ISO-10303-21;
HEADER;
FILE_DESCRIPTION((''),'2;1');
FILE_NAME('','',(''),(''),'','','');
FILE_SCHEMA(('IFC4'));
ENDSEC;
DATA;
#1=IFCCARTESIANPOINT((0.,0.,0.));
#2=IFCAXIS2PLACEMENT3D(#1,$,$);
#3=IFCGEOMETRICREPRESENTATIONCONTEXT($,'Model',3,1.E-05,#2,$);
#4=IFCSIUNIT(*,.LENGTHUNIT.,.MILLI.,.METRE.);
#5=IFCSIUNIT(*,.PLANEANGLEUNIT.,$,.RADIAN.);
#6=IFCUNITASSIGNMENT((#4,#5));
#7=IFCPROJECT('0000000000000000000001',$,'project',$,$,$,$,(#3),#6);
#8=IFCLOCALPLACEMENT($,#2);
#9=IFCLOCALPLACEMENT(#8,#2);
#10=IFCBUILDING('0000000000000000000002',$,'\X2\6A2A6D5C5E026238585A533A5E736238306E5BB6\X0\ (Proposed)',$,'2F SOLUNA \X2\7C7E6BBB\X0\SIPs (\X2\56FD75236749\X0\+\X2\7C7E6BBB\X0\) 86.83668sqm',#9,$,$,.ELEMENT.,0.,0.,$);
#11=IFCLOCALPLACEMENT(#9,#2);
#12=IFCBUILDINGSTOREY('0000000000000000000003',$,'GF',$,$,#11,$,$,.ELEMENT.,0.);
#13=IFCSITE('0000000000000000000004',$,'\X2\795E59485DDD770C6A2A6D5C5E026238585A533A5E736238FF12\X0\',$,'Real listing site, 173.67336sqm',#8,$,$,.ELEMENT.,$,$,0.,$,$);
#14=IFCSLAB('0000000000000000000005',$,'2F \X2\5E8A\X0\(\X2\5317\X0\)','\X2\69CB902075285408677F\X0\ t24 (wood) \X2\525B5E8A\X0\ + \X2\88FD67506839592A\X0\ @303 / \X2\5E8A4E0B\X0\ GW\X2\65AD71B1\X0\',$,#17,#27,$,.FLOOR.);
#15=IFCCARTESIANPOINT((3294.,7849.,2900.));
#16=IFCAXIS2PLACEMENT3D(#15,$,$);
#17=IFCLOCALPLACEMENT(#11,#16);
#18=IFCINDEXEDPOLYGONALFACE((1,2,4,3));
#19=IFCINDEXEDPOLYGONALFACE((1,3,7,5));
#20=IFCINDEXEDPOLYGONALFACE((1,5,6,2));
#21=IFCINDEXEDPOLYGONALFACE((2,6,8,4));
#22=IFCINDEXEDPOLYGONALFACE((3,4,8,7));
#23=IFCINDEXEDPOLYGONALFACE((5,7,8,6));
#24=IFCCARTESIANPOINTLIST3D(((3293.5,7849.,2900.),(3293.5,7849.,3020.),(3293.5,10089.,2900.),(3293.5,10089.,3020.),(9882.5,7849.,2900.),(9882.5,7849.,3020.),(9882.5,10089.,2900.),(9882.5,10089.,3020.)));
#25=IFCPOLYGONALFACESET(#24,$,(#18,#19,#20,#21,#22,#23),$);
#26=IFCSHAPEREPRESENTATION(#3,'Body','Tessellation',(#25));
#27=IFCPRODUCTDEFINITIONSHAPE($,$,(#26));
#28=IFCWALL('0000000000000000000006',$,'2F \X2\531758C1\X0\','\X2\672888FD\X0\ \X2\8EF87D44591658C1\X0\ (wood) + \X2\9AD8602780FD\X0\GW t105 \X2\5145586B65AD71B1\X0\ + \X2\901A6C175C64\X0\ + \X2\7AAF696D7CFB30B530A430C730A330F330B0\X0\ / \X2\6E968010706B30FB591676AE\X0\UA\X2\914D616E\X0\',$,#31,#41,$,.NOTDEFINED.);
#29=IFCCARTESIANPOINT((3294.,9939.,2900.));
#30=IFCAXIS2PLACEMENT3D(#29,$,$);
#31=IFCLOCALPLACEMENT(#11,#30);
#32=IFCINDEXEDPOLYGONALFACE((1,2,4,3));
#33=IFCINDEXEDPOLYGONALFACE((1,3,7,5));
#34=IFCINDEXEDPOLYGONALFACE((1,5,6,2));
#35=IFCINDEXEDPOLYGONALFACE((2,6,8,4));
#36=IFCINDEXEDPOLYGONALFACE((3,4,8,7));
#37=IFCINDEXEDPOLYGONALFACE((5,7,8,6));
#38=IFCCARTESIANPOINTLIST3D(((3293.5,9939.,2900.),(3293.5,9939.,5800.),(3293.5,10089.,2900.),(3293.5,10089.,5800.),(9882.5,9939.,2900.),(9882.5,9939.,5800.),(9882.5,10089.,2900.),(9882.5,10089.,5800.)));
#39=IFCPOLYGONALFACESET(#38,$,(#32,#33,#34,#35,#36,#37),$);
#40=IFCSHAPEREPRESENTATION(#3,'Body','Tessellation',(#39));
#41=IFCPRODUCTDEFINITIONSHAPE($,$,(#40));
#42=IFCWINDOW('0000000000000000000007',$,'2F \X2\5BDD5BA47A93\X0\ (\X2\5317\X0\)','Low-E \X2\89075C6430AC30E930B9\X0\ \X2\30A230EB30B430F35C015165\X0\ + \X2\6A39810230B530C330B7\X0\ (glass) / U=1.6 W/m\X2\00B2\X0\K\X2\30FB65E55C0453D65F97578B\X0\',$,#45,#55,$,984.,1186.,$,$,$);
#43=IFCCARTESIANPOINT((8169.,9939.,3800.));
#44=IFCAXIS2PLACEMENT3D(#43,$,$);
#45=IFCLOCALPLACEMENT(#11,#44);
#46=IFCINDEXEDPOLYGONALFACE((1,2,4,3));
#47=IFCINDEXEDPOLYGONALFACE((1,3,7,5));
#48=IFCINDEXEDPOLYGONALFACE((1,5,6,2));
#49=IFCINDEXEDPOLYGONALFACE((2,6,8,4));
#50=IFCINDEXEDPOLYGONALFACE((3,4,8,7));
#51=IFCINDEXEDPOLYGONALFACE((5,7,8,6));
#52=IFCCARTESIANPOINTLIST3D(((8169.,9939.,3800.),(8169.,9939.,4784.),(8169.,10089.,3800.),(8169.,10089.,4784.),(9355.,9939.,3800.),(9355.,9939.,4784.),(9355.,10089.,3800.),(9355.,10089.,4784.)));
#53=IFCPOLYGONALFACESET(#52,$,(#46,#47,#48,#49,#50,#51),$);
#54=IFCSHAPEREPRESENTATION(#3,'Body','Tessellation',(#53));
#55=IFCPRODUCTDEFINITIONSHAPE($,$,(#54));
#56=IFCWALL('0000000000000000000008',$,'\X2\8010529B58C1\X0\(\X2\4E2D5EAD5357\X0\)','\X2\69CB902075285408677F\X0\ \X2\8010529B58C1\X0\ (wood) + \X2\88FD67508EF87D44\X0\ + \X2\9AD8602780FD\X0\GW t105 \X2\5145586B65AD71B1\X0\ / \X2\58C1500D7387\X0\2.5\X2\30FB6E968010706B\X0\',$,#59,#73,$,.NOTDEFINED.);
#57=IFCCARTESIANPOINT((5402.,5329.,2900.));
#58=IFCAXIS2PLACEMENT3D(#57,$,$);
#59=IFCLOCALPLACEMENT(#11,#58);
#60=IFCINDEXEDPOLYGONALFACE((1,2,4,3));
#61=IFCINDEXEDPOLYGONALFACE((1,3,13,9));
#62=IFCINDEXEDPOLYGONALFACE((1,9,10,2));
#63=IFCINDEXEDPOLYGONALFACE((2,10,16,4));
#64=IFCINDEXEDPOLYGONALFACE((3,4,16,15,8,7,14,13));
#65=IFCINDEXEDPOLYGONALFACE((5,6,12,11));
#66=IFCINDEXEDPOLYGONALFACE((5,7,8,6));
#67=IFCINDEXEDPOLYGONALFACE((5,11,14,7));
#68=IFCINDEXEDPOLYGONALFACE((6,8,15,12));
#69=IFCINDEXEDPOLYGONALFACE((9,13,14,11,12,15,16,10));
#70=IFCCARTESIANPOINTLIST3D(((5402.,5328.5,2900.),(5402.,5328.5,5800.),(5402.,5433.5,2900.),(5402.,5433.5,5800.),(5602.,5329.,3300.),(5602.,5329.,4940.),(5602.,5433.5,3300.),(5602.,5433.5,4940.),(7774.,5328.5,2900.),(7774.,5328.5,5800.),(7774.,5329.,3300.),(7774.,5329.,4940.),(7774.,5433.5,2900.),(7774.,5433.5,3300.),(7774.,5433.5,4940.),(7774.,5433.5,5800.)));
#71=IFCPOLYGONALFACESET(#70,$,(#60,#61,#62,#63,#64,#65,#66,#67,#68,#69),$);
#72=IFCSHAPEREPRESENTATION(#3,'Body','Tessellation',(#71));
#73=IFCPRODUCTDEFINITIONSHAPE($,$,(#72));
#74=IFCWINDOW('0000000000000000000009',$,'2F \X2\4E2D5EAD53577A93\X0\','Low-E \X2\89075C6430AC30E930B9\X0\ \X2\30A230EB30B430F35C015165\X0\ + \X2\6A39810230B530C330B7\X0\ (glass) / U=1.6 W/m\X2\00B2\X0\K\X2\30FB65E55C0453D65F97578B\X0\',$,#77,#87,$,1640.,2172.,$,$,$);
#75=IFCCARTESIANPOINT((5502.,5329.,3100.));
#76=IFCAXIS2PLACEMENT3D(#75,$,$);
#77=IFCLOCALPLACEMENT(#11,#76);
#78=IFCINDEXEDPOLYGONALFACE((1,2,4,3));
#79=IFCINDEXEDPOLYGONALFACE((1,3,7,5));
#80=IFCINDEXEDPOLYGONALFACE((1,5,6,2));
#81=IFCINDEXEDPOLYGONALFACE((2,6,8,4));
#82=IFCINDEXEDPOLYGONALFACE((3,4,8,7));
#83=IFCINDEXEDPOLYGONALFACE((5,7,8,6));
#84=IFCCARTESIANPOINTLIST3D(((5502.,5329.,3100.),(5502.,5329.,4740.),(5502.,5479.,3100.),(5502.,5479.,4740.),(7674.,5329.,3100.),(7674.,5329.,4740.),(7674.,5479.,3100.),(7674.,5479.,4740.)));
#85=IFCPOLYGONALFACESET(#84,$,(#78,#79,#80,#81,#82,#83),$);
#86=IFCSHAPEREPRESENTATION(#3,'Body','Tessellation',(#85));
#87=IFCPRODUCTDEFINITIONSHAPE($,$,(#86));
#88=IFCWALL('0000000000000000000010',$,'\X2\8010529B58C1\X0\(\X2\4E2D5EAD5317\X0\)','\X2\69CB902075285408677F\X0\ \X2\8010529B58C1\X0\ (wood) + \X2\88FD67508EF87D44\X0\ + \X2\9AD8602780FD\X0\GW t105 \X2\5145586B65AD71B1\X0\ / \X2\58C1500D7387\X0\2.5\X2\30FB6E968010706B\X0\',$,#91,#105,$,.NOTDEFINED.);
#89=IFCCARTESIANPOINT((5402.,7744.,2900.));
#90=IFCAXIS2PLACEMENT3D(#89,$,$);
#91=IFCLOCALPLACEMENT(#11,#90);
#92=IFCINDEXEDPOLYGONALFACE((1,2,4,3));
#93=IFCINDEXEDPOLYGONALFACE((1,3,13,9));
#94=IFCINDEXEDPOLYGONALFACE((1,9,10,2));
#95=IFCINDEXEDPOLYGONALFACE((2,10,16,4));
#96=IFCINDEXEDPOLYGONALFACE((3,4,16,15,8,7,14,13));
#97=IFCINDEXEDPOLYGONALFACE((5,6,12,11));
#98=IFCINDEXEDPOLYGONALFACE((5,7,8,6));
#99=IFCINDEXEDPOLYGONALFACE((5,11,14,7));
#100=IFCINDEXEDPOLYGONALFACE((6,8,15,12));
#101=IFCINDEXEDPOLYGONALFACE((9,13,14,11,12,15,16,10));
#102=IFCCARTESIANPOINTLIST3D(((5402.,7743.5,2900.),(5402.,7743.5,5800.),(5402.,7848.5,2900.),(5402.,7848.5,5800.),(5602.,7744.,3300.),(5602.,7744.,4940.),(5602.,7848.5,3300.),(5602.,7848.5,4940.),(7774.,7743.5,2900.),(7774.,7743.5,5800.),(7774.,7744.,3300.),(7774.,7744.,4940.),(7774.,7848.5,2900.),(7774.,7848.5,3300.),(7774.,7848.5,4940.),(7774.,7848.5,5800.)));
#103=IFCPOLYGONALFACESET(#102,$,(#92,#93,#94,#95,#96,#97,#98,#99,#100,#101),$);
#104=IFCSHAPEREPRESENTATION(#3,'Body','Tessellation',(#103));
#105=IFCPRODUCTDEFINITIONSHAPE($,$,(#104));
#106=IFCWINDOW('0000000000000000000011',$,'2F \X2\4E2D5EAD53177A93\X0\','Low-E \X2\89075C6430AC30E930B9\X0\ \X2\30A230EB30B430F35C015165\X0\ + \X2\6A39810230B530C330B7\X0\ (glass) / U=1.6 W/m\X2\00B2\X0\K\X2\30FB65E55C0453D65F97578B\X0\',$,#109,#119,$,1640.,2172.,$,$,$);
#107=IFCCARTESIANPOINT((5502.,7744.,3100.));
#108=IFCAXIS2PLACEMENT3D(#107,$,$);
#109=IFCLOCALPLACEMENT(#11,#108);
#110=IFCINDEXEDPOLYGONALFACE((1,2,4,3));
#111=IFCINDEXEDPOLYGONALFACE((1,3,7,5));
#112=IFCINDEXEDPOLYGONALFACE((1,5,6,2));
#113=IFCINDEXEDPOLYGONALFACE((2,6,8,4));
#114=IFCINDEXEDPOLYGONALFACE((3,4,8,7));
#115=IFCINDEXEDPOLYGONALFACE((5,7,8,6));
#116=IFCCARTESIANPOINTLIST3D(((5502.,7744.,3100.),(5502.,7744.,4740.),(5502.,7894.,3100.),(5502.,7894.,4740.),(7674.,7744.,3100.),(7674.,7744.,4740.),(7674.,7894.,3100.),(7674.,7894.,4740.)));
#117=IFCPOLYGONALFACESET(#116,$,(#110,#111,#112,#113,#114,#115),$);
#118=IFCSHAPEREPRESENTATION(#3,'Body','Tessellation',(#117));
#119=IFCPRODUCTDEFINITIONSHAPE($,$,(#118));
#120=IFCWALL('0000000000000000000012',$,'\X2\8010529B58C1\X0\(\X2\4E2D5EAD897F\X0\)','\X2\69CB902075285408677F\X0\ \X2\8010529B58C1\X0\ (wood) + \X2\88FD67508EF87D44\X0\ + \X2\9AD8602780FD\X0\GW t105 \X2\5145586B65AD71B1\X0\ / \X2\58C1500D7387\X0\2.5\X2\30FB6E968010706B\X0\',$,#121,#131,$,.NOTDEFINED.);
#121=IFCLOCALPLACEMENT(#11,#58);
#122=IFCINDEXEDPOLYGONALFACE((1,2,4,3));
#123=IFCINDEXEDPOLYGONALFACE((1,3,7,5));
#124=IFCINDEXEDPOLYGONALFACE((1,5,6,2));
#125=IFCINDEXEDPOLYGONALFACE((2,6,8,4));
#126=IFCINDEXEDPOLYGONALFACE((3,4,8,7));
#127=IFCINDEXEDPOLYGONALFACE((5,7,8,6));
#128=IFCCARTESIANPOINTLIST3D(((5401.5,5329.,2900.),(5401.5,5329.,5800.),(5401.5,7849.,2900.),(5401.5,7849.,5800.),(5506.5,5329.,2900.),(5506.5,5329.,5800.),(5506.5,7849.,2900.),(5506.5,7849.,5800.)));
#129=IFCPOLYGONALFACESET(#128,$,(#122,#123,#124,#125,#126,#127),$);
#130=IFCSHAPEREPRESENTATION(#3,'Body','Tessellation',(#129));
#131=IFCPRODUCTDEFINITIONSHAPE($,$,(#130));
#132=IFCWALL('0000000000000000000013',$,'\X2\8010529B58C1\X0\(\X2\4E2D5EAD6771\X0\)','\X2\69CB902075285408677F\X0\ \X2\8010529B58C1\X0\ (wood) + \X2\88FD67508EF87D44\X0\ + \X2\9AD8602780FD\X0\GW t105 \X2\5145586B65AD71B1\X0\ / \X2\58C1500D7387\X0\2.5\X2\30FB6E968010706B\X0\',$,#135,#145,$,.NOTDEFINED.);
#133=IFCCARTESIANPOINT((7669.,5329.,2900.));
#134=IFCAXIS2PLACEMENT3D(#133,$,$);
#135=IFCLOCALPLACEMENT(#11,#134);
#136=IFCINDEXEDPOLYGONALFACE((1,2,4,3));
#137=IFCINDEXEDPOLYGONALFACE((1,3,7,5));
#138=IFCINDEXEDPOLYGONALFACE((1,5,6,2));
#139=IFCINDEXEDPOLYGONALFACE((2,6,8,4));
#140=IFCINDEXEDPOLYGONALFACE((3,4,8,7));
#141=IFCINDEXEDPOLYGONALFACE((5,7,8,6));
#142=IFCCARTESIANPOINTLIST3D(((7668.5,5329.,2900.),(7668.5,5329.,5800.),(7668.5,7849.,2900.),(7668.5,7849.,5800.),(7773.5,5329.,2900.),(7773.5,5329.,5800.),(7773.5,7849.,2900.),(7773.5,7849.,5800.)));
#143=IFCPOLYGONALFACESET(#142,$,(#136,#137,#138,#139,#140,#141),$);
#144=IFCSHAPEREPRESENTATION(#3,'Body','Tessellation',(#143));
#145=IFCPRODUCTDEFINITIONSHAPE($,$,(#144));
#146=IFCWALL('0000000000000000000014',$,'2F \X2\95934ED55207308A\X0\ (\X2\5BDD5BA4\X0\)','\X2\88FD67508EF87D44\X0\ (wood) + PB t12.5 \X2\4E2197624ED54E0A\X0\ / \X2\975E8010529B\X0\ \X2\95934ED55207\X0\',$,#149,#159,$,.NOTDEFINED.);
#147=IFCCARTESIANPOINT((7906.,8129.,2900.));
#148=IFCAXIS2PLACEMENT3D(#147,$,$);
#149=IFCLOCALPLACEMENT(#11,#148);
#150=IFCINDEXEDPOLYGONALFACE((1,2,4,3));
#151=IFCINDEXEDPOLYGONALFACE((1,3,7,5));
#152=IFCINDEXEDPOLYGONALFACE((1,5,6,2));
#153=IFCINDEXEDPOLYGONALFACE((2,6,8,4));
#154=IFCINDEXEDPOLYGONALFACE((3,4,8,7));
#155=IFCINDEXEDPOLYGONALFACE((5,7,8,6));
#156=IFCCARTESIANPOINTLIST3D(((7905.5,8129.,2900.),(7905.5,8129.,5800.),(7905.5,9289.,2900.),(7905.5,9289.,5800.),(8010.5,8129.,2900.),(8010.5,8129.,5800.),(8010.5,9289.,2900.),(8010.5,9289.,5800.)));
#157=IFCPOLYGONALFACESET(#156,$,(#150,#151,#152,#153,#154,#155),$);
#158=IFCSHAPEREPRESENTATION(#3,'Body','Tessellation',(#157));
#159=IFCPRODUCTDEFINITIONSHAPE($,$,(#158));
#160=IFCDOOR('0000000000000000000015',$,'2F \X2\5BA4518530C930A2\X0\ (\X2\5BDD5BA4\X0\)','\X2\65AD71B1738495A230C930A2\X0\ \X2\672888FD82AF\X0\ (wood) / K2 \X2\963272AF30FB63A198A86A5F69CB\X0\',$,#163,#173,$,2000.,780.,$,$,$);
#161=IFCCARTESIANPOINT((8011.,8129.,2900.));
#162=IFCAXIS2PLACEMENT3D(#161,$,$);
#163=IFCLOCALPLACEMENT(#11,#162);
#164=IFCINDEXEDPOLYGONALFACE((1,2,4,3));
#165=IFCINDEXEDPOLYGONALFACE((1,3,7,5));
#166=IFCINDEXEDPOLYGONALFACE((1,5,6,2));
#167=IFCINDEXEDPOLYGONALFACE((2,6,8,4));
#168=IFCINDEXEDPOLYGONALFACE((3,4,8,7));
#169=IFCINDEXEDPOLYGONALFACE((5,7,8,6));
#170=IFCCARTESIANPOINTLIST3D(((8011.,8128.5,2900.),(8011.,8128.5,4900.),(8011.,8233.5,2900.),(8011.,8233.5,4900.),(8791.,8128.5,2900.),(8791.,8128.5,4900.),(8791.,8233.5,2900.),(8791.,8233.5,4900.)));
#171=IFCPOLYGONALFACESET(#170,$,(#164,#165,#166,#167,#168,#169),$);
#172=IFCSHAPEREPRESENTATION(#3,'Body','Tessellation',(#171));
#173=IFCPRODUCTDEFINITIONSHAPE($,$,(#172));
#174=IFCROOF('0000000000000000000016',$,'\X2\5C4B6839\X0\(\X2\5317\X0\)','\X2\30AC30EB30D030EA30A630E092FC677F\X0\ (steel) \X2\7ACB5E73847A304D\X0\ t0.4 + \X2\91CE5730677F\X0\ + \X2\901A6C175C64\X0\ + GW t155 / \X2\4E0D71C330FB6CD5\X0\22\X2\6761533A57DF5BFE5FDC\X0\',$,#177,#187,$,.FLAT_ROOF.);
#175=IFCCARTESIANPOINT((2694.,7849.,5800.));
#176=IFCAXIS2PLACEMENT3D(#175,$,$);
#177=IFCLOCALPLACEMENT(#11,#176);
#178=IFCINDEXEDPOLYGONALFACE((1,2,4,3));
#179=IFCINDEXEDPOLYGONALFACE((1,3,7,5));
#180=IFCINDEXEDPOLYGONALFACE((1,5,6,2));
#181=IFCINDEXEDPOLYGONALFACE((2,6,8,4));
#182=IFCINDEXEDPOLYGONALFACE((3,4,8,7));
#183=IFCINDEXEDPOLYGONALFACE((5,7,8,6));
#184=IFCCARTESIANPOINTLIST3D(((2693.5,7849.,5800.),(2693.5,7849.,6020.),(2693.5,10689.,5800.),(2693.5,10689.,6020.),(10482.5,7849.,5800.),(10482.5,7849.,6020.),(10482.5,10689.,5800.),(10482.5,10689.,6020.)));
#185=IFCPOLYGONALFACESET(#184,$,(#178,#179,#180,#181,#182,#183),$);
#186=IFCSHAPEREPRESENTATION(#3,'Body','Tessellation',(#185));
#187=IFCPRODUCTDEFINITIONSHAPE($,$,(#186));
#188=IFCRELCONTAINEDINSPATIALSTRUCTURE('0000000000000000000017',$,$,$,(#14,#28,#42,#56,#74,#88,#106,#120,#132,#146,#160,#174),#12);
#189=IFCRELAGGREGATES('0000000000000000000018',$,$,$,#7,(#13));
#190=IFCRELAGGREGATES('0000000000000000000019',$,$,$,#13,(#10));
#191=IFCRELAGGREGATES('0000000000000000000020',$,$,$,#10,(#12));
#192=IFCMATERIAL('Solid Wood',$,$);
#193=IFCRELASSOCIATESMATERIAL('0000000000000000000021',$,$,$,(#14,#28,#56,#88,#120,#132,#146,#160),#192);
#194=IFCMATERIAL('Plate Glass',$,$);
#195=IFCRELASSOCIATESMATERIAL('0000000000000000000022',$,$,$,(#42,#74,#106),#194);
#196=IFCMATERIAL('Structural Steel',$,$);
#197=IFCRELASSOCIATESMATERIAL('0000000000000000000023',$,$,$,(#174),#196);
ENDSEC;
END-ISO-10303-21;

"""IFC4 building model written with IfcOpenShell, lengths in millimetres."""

from ifc_helpers import new_model, si_unit, frame, frame_2d, origin, place, context, project, spatial, rectangle, extrude, material, element, fill, save


model = new_model("IFC4")

# Units and contexts
model_context = context("Model", 3, precision=1e-05, world=origin())
ifc_project = project(units=[si_unit("LENGTHUNIT", "METRE", prefix="MILLI"), si_unit("PLANEANGLEUNIT", "RADIAN")], contexts=[model_context])

# Site, building, storey
site_placement = place(None, origin())
site = spatial("IfcSite", under=ifc_project, at=site_placement, Name="神奈川県横浜市戸塚区平戸２", ObjectType="Real listing site, 173.67336sqm", CompositionType="ELEMENT", RefElevation=0.0)
building_placement = place(site_placement, origin())
building = spatial("IfcBuilding", under=site, at=building_placement, Name="横浜市戸塚区平戸の家 (Proposed)", ObjectType="2F SOLUNA 籾殻SIPs (国産杉+籾殻) 86.83668sqm", CompositionType="ELEMENT", ElevationOfRefHeight=0.0, ElevationOfTerrain=0.0)
storey_placement = place(building_placement, origin())
storey = spatial("IfcBuildingStorey", under=building, at=storey_placement, Name="GF", CompositionType="ELEMENT", Elevation=0.0)

# Slab
ifc_material_1 = material(Name="Solid Wood")
slab_placement = place(storey_placement, frame((3294.0, 7849.0, 2900.0)))
element("IfcSlab", 1, at=slab_placement, inside=storey, material=ifc_material_1, Name="2F 床(北)", Description="構造用合板 t24 (wood) 剛床 + 製材根太 @303 / 床下 GW断熱", PredefinedType="FLOOR", context=model_context, shape_type="SweptSolid", body=[
    extrude(rectangle(XDim=6589.0, YDim=2240.0, at=frame_2d((3294.0, 1120.0))), frame((3294.0, 7849.0, 2900.0)), (0.0, 0.0, 1.0), 120.0),
])

# Walls, openings, windows
wall_1_placement = place(storey_placement, frame((3294.0, 9939.0, 2900.0)))
wall_1 = element("IfcWall", 2, at=wall_1_placement, inside=storey, material=ifc_material_1, Name="2F 北壁", Description="木製 軸組外壁 (wood) + 高性能GW t105 充填断熱 + 通気層 + 窯業系サイディング / 準耐火・外皮UA配慮", PredefinedType="NOTDEFINED", context=model_context, shape_type="SweptSolid", body=[
    extrude(rectangle(XDim=6589.0, YDim=150.0, at=frame_2d((3294.0, 75.0))), frame((3294.0, 9939.0, 2900.0)), (0.0, 0.0, 1.0), 2900.0),
])
opening_1_placement = place(storey_placement, frame((8169.0, 9939.0, 3800.0)))
opening_1 = element("IfcOpeningElement", 3, at=opening_1_placement, cuts=wall_1, PredefinedType="NOTDEFINED", context=model_context, shape_type="SweptSolid", body=[
    extrude(rectangle(XDim=1186.0, YDim=150.0, at=frame_2d((593.0, 75.0))), frame((8169.0, 9939.0, 3800.0)), (0.0, 0.0, 1.0), 984.0),
])
ifc_material_2 = material(Name="Plate Glass")
window_1_placement = place(storey_placement, frame((8169.0, 9939.0, 3800.0)))
window_1 = element("IfcWindow", 4, at=window_1_placement, inside=storey, material=ifc_material_2, Name="2F 寝室窓 (北)", Description="Low-E 複層ガラス アルゴン封入 + 樹脂サッシ (glass) / U=1.6 W/m²K・日射取得型", OverallHeight=984.0, OverallWidth=1186.0, context=model_context, shape_type="SweptSolid", body=[
    extrude(rectangle(XDim=1186.0, YDim=150.0, at=frame_2d((593.0, 75.0))), frame((8169.0, 9939.0, 3800.0)), (0.0, 0.0, 1.0), 984.0),
])
fill(opening_1, window_1)
wall_2_placement = place(storey_placement, frame((5402.0, 5329.0, 2900.0)))
wall_2 = element("IfcWall", 5, at=wall_2_placement, inside=storey, material=ifc_material_1, Name="耐力壁(中庭南)", Description="構造用合板 耐力壁 (wood) + 製材軸組 + 高性能GW t105 充填断熱 / 壁倍率2.5・準耐火", PredefinedType="NOTDEFINED", context=model_context, shape_type="SweptSolid", body=[
    extrude(rectangle(XDim=2372.0, YDim=105.0, at=frame_2d((1186.0, 52.0))), frame((5402.0, 5329.0, 2900.0)), (0.0, 0.0, 1.0), 2900.0),
])
opening_2_placement = place(storey_placement, frame((5502.0, 5329.0, 3100.0)))
opening_2 = element("IfcOpeningElement", 6, at=opening_2_placement, cuts=wall_2, PredefinedType="NOTDEFINED", context=model_context, shape_type="SweptSolid", body=[
    extrude(rectangle(XDim=2172.0, YDim=150.0, at=frame_2d((1086.0, 75.0))), frame((5502.0, 5329.0, 3100.0)), (0.0, 0.0, 1.0), 1640.0),
])
window_2_placement = place(storey_placement, frame((5502.0, 5329.0, 3100.0)))
window_2 = element("IfcWindow", 7, at=window_2_placement, inside=storey, material=ifc_material_2, Name="2F 中庭南窓", Description="Low-E 複層ガラス アルゴン封入 + 樹脂サッシ (glass) / U=1.6 W/m²K・日射取得型", OverallHeight=1640.0, OverallWidth=2172.0, context=model_context, shape_type="SweptSolid", body=[
    extrude(rectangle(XDim=2172.0, YDim=150.0, at=frame_2d((1086.0, 75.0))), frame((5502.0, 5329.0, 3100.0)), (0.0, 0.0, 1.0), 1640.0),
])
fill(opening_2, window_2)
wall_3_placement = place(storey_placement, frame((5402.0, 7744.0, 2900.0)))
wall_3 = element("IfcWall", 8, at=wall_3_placement, inside=storey, material=ifc_material_1, Name="耐力壁(中庭北)", Description="構造用合板 耐力壁 (wood) + 製材軸組 + 高性能GW t105 充填断熱 / 壁倍率2.5・準耐火", PredefinedType="NOTDEFINED", context=model_context, shape_type="SweptSolid", body=[
    extrude(rectangle(XDim=2372.0, YDim=105.0, at=frame_2d((1186.0, 52.0))), frame((5402.0, 7744.0, 2900.0)), (0.0, 0.0, 1.0), 2900.0),
])
opening_3_placement = place(storey_placement, frame((5502.0, 7744.0, 3100.0)))
opening_3 = element("IfcOpeningElement", 9, at=opening_3_placement, cuts=wall_3, PredefinedType="NOTDEFINED", context=model_context, shape_type="SweptSolid", body=[
    extrude(rectangle(XDim=2172.0, YDim=150.0, at=frame_2d((1086.0, 75.0))), frame((5502.0, 7744.0, 3100.0)), (0.0, 0.0, 1.0), 1640.0),
])
window_3_placement = place(storey_placement, frame((5502.0, 7744.0, 3100.0)))
window_3 = element("IfcWindow", 10, at=window_3_placement, inside=storey, material=ifc_material_2, Name="2F 中庭北窓", Description="Low-E 複層ガラス アルゴン封入 + 樹脂サッシ (glass) / U=1.6 W/m²K・日射取得型", OverallHeight=1640.0, OverallWidth=2172.0, context=model_context, shape_type="SweptSolid", body=[
    extrude(rectangle(XDim=2172.0, YDim=150.0, at=frame_2d((1086.0, 75.0))), frame((5502.0, 7744.0, 3100.0)), (0.0, 0.0, 1.0), 1640.0),
])
fill(opening_3, window_3)

# Walls
wall_4_placement = place(storey_placement, frame((5402.0, 5329.0, 2900.0)))
element("IfcWall", 11, at=wall_4_placement, inside=storey, material=ifc_material_1, Name="耐力壁(中庭西)", Description="構造用合板 耐力壁 (wood) + 製材軸組 + 高性能GW t105 充填断熱 / 壁倍率2.5・準耐火", PredefinedType="NOTDEFINED", context=model_context, shape_type="SweptSolid", body=[
    extrude(rectangle(XDim=105.0, YDim=2520.0, at=frame_2d((52.0, 1260.0))), frame((5402.0, 5329.0, 2900.0)), (0.0, 0.0, 1.0), 2900.0),
])
wall_5_placement = place(storey_placement, frame((7669.0, 5329.0, 2900.0)))
element("IfcWall", 12, at=wall_5_placement, inside=storey, material=ifc_material_1, Name="耐力壁(中庭東)", Description="構造用合板 耐力壁 (wood) + 製材軸組 + 高性能GW t105 充填断熱 / 壁倍率2.5・準耐火", PredefinedType="NOTDEFINED", context=model_context, shape_type="SweptSolid", body=[
    extrude(rectangle(XDim=105.0, YDim=2520.0, at=frame_2d((52.0, 1260.0))), frame((7669.0, 5329.0, 2900.0)), (0.0, 0.0, 1.0), 2900.0),
])
wall_6_placement = place(storey_placement, frame((7906.0, 8129.0, 2900.0)))
element("IfcWall", 13, at=wall_6_placement, inside=storey, material=ifc_material_1, Name="2F 間仕切り (寝室)", Description="製材軸組 (wood) + PB t12.5 両面仕上 / 非耐力 間仕切", PredefinedType="NOTDEFINED", context=model_context, shape_type="SweptSolid", body=[
    extrude(rectangle(XDim=105.0, YDim=1160.0, at=frame_2d((52.0, 580.0))), frame((7906.0, 8129.0, 2900.0)), (0.0, 0.0, 1.0), 2900.0),
])

# Door
door_placement = place(storey_placement, frame((8011.0, 8129.0, 2900.0)))
element("IfcDoor", 14, at=door_placement, inside=storey, material=ifc_material_1, Name="2F 室内ドア (寝室)", Description="断熱玄関ドア 木製芯 (wood) / K2 防犯・採風機構", OverallHeight=2000.0, OverallWidth=780.0, context=model_context, shape_type="SweptSolid", body=[
    extrude(rectangle(XDim=780.0, YDim=105.0, at=frame_2d((390.0, 52.0))), frame((8011.0, 8129.0, 2900.0)), (0.0, 0.0, 1.0), 2000.0),
])

# Roof
ifc_material_3 = material(Name="Structural Steel")
for number, where, name in (
    (15, (2694.0, 7849.0, 5800.0), "屋根(北)"),
):
    element("IfcRoof", number, at=place(storey_placement, frame(where)), inside=storey, material=ifc_material_3, Name=name, Description="ガルバリウム鋼板 (steel) 立平葺き t0.4 + 野地板 + 通気層 + GW t155 / 不燃・法22条区域対応", PredefinedType="FLAT_ROOF", context=model_context, shape_type="SweptSolid", body=[
        extrude(rectangle(XDim=7789.0, YDim=2840.0, at=frame_2d((3894.0, 1420.0))), frame((2694.0, 7849.0, 5800.0)), (0.0, 0.0, 1.0), 220.0),
    ])

save(model, "model.ifc")
